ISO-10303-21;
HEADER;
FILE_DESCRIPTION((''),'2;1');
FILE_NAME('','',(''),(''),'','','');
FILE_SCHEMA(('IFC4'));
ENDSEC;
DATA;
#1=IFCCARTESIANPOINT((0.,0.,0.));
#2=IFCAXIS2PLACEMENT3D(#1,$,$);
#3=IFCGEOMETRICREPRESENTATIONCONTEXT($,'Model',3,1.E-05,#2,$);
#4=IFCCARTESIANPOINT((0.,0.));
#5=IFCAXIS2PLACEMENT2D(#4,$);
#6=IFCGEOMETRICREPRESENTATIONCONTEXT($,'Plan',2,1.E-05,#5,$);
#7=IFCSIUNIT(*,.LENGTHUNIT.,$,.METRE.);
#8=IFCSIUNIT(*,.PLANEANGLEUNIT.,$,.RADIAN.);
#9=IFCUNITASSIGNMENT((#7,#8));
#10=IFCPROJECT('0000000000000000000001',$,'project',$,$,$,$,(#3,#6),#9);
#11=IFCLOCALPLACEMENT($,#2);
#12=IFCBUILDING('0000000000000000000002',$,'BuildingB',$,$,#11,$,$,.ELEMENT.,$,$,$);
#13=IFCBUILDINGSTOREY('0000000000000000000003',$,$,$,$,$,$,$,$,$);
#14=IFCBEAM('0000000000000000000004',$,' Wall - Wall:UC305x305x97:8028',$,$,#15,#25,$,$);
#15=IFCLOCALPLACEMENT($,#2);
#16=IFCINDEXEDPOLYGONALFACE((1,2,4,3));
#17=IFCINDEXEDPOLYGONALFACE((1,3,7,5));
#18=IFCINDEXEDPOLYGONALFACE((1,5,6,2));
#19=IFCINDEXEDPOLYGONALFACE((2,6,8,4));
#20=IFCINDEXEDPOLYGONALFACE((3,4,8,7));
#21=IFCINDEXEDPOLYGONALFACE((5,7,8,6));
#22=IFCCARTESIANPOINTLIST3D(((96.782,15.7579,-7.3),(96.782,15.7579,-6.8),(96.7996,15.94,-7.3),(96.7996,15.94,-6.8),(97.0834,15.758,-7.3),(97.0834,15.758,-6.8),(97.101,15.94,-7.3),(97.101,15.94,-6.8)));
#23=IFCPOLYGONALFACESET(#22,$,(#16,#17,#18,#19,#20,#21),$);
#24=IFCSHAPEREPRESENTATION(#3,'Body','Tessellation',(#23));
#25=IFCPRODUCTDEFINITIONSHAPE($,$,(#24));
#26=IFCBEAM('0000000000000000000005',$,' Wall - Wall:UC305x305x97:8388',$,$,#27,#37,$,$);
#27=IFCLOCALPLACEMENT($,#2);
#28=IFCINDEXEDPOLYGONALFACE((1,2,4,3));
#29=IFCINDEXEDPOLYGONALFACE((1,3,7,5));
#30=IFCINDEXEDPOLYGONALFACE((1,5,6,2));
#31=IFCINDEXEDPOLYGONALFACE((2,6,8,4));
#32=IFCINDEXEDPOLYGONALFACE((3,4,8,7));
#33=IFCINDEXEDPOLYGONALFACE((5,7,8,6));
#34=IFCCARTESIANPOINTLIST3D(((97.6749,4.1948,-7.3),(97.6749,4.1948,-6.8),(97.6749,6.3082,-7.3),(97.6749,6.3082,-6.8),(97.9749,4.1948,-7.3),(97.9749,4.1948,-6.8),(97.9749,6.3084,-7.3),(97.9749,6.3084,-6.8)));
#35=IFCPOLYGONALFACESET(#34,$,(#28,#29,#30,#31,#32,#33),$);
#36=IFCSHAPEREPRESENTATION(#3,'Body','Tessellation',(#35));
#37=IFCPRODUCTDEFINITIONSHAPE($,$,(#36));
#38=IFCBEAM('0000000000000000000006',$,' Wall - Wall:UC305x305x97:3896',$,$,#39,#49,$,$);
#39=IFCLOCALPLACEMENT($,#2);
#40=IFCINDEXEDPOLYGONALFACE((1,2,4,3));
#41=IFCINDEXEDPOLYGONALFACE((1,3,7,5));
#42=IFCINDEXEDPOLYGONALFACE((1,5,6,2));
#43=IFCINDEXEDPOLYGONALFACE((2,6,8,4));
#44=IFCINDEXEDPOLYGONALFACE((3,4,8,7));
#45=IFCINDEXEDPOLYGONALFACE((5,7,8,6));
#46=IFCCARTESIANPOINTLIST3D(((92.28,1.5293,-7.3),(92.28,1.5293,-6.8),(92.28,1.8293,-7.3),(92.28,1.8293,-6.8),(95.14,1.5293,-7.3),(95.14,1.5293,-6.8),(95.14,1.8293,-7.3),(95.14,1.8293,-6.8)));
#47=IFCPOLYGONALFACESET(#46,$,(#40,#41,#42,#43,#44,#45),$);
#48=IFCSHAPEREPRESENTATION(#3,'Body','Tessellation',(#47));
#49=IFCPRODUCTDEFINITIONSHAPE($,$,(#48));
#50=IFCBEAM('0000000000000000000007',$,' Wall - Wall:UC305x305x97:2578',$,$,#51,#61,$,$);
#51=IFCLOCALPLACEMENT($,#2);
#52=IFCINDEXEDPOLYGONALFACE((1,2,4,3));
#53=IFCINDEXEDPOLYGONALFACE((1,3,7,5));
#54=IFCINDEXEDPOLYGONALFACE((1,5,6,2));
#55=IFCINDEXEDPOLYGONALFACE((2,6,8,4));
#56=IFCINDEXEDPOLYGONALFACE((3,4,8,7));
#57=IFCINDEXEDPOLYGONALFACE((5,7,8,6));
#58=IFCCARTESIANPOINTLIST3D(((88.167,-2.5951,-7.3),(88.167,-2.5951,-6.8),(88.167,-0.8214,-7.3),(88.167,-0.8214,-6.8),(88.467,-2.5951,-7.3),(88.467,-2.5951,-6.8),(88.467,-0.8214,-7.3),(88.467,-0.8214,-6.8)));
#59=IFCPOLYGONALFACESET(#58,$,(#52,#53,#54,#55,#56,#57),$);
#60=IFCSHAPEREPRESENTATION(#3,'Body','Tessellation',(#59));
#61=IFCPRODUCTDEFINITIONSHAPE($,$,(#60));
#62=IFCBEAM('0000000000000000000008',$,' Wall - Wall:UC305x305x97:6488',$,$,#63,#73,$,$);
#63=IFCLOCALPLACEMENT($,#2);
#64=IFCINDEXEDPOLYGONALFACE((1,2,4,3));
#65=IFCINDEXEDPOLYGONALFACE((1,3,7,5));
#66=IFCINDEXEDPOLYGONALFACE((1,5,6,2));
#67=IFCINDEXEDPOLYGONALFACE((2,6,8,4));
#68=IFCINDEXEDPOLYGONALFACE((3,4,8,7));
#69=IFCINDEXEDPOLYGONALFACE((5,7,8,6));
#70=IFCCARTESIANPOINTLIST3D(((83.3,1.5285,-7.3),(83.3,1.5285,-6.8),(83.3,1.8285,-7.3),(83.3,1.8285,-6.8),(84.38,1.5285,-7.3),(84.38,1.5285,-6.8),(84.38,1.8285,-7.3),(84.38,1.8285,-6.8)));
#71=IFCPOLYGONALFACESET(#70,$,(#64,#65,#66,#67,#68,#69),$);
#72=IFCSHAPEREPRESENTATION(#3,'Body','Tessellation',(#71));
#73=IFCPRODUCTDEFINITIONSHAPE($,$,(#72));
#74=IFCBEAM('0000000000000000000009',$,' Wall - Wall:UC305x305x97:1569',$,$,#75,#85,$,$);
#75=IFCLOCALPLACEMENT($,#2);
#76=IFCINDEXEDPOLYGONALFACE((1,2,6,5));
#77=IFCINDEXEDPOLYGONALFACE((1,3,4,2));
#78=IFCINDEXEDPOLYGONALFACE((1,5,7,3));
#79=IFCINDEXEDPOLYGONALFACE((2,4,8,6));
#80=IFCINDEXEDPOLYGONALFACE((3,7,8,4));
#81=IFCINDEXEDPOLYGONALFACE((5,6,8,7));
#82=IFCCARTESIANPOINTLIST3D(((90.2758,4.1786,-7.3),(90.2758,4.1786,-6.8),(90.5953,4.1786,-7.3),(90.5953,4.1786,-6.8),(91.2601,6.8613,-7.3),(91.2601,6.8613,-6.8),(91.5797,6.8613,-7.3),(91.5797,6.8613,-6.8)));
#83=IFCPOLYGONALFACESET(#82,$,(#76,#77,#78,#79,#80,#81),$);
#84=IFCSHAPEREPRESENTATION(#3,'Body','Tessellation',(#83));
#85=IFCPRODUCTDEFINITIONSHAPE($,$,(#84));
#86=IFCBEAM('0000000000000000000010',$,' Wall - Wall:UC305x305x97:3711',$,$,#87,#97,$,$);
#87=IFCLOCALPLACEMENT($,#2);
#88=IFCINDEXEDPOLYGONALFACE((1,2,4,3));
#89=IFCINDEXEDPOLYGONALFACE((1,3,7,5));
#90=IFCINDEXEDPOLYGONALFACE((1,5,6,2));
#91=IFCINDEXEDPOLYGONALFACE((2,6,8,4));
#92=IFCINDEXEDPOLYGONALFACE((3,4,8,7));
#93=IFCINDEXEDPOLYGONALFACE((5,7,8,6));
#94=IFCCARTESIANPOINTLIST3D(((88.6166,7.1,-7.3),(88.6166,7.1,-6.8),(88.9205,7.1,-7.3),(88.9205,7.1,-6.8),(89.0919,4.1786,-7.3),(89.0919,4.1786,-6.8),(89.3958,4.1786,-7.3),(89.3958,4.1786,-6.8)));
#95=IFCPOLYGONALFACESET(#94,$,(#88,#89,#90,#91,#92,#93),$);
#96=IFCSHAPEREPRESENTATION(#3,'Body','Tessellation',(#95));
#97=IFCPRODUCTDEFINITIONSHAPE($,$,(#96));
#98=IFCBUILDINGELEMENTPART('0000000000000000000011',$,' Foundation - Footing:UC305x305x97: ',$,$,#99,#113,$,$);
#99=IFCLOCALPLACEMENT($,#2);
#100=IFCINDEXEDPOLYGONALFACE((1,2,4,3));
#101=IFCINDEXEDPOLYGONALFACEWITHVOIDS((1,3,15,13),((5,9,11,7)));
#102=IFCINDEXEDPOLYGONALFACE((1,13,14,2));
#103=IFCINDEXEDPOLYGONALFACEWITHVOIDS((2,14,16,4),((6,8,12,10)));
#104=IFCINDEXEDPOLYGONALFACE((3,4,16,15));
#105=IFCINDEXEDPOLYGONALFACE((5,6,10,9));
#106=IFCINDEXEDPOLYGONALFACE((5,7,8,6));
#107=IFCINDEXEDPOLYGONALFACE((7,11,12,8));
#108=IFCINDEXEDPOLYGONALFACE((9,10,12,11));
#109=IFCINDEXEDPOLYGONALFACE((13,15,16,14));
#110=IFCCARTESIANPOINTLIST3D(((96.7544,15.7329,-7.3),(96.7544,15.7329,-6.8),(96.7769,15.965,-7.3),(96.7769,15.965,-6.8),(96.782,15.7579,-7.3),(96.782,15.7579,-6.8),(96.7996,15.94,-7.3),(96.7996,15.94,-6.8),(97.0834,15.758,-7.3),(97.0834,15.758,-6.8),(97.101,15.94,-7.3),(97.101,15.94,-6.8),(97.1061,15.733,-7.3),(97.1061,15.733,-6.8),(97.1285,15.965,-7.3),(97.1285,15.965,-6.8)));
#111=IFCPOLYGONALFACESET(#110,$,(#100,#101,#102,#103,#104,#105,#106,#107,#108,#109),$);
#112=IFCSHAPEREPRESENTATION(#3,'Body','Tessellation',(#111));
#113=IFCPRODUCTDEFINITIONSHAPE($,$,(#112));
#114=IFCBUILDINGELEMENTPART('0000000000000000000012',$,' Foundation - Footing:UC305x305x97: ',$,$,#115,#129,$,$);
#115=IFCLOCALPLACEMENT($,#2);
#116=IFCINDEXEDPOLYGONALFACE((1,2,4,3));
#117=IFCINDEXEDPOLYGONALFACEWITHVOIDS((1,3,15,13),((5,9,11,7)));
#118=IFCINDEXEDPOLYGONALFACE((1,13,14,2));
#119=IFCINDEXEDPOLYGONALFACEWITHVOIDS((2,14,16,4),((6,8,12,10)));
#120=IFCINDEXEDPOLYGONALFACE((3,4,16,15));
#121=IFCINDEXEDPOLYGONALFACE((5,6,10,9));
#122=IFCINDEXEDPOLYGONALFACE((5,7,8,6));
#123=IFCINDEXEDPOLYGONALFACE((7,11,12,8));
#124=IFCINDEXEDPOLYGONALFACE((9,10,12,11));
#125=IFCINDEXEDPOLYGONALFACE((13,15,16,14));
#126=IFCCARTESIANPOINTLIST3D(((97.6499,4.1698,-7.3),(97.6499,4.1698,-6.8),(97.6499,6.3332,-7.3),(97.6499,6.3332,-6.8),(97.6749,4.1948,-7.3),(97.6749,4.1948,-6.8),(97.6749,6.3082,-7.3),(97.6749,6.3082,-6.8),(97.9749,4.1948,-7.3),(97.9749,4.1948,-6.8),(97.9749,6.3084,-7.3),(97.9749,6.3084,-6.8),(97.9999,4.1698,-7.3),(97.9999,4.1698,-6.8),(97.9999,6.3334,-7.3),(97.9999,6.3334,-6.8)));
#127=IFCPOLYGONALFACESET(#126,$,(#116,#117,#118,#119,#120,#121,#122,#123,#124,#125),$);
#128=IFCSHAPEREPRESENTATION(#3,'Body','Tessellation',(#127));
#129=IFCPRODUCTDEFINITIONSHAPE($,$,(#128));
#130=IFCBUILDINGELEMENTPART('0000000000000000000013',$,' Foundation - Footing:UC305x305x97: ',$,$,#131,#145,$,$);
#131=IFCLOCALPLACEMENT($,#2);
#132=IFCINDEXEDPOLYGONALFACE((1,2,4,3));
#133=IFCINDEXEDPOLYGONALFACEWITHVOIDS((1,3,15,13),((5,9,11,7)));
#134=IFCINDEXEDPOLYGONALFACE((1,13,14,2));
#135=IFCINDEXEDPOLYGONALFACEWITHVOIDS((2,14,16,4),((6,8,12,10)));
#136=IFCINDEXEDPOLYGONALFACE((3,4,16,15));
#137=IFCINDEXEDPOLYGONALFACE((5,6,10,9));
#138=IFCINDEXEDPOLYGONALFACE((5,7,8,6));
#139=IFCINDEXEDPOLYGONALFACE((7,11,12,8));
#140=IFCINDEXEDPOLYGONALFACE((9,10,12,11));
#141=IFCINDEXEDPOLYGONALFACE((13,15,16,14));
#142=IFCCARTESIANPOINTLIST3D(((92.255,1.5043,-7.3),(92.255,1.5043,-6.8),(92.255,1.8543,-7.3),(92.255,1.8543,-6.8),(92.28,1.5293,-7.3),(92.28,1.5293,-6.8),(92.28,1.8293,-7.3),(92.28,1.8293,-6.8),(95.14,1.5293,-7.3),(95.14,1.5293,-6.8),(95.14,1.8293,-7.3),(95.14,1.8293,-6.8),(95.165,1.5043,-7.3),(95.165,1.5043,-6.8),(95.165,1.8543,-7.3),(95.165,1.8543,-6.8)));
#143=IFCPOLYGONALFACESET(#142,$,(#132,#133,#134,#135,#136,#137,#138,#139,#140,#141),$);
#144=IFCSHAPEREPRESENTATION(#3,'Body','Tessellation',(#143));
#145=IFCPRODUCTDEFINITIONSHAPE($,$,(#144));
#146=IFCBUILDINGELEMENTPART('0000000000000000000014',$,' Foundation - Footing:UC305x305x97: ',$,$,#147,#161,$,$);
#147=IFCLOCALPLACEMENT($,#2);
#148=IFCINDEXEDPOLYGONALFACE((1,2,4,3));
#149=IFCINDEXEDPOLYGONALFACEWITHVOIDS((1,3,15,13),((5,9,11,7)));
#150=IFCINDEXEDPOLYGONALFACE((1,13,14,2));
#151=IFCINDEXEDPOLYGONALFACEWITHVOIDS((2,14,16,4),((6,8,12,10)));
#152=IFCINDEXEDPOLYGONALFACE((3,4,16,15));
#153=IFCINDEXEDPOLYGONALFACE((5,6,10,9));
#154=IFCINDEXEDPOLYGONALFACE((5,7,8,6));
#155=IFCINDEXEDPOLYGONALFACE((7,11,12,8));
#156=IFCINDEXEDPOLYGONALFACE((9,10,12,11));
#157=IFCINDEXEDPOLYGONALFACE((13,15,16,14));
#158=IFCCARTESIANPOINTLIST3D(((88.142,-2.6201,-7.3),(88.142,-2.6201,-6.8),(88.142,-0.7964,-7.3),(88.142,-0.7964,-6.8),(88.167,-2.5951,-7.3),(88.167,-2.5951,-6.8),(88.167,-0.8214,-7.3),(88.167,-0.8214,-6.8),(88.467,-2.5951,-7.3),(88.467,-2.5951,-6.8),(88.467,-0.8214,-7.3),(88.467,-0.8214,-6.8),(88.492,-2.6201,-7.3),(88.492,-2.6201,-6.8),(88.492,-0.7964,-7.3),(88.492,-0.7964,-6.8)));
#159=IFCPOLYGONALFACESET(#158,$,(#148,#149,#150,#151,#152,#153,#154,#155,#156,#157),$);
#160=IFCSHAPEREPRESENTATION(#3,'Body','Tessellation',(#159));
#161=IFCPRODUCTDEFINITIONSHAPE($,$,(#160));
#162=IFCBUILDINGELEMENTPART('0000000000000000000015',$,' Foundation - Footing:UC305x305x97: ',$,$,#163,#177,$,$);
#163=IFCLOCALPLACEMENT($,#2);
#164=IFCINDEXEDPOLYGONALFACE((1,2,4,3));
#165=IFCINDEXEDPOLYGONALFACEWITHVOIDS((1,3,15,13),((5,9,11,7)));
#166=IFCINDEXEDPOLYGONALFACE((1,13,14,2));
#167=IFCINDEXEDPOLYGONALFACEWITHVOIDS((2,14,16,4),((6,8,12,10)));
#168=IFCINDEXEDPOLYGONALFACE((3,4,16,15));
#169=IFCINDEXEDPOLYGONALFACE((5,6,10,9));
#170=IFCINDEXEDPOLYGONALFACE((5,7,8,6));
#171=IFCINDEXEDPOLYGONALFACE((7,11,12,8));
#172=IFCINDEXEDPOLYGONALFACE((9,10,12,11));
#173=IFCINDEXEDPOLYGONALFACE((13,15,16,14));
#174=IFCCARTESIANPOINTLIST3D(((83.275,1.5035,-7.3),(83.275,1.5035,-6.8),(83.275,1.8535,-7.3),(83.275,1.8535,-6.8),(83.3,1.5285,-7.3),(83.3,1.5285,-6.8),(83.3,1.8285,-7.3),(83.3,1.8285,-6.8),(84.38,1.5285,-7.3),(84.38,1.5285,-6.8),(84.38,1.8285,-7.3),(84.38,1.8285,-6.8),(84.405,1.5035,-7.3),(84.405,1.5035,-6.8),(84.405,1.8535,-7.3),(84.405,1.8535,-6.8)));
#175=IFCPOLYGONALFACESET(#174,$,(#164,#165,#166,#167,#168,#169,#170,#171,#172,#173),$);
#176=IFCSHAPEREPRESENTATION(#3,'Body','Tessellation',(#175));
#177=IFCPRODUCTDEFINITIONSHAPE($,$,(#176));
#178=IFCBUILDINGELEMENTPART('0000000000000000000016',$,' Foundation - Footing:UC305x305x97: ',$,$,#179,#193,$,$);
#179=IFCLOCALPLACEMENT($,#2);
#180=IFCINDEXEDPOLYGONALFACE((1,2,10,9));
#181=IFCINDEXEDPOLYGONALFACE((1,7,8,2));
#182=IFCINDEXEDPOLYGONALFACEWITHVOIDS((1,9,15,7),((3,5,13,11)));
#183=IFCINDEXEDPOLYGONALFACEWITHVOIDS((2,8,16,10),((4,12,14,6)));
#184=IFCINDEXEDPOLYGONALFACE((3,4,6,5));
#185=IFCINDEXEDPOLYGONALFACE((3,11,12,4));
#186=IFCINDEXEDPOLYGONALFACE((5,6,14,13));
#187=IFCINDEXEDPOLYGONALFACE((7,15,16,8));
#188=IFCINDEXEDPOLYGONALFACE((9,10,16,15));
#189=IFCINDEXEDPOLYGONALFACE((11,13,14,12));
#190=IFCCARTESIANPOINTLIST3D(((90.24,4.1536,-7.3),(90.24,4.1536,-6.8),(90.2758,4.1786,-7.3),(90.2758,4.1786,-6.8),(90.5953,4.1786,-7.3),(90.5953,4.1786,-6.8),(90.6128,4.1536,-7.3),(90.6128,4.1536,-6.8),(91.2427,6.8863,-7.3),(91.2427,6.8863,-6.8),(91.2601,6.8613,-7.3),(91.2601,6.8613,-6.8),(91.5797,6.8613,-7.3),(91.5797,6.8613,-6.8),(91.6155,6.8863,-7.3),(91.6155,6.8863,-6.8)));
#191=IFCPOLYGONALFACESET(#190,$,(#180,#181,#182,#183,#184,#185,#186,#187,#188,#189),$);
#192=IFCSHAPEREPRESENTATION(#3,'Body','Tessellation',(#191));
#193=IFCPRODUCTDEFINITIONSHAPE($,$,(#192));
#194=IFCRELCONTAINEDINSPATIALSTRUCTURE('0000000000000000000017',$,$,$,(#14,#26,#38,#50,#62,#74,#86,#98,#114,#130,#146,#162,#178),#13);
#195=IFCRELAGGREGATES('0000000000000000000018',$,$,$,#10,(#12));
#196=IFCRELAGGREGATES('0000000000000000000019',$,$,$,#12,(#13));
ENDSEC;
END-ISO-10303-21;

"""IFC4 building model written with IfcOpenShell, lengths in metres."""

from ifc_helpers import new_model, si_unit, origin, origin_2d, place, context, project, spatial, polyline, outline, extrude, element, save


model = new_model("IFC4")

# Units and contexts
model_context = context("Model", 3, precision=1e-05, world=origin())
plan_context = context("Plan", 2, precision=1e-05, world=origin_2d())
ifc_project = project(units=[si_unit("LENGTHUNIT", "METRE"), si_unit("PLANEANGLEUNIT", "RADIAN")], contexts=[model_context, plan_context])

# Building, storey
building_placement = place(None, origin())
building = spatial("IfcBuilding", under=ifc_project, at=building_placement, Name="BuildingB", CompositionType="ELEMENT")
storey = spatial("IfcBuildingStorey", under=building)

# Beams
element("IfcBeam", 1, inside=storey, Name=" Wall - Wall:UC305x305x97:8028", context=model_context, shape_type="SweptSolid", body=[
    extrude(outline(polyline([(97.0834, 15.758, -7.3), (97.101, 15.94, -7.3), (96.7996, 15.94, -7.3), (96.782, 15.7579, -7.3), (97.0834, 15.758, -7.3)])), None, (0.0, 0.0, 1.0), 0.5),
])
element("IfcBeam", 2, inside=storey, Name=" Wall - Wall:UC305x305x97:8388", context=model_context, shape_type="SweptSolid", body=[
    extrude(outline(polyline([(97.9749, 4.1948, -7.3), (97.9749, 6.3084, -7.3), (97.6749, 6.3082, -7.3), (97.6749, 4.1948, -7.3), (97.9749, 4.1948, -7.3)])), None, (0.0, 0.0, 1.0), 0.5),
])
element("IfcBeam", 3, inside=storey, Name=" Wall - Wall:UC305x305x97:3896", context=model_context, shape_type="SweptSolid", body=[
    extrude(outline(polyline([(95.14, 1.5293, -7.3), (95.14, 1.8293, -7.3), (92.28, 1.8293, -7.3), (92.28, 1.5293, -7.3), (95.14, 1.5293, -7.3)])), None, (0.0, 0.0, 1.0), 0.5),
])
element("IfcBeam", 4, inside=storey, Name=" Wall - Wall:UC305x305x97:2578", context=model_context, shape_type="SweptSolid", body=[
    extrude(outline(polyline([(88.467, -2.5951, -7.3), (88.467, -0.8214, -7.3), (88.167, -0.8214, -7.3), (88.167, -2.5951, -7.3), (88.467, -2.5951, -7.3)])), None, (0.0, 0.0, 1.0), 0.5),
])
element("IfcBeam", 5, inside=storey, Name=" Wall - Wall:UC305x305x97:6488", context=model_context, shape_type="SweptSolid", body=[
    extrude(outline(polyline([(84.38, 1.5285, -7.3), (84.38, 1.8285, -7.3), (83.3, 1.8285, -7.3), (83.3, 1.5285, -7.3), (84.38, 1.5285, -7.3)])), None, (0.0, 0.0, 1.0), 0.5),
])
element("IfcBeam", 6, inside=storey, Name=" Wall - Wall:UC305x305x97:1569", context=model_context, shape_type="SweptSolid", body=[
    extrude(outline(polyline([(90.5953, 4.1786, -7.3), (90.2758, 4.1786, -7.3), (91.2601, 6.8613, -7.3), (91.5797, 6.8613, -7.3), (90.5953, 4.1786, -7.3)])), None, (0.0, 0.0, 1.0), 0.5),
])
element("IfcBeam", 7, inside=storey, Name=" Wall - Wall:UC305x305x97:3711", context=model_context, shape_type="SweptSolid", body=[
    extrude(outline(polyline([(89.3958, 4.1786, -7.3), (89.0919, 4.1786, -7.3), (88.6166, 7.1, -7.3), (88.9205, 7.1, -7.3), (89.3958, 4.1786, -7.3)])), None, (0.0, 0.0, 1.0), 0.5),
])

# Building element parts, openings
building_element_part_1 = element("IfcBuildingElementPart", 8, inside=storey, Name=" Foundation - Footing:UC305x305x97: ", context=model_context, shape_type="SweptSolid", body=[
    extrude(outline(polyline([(97.1061, 15.733, -7.3), (97.1285, 15.965, -7.3), (96.7769, 15.965, -7.3), (96.7544, 15.7329, -7.3), (97.1061, 15.733, -7.3)])), None, (0.0, 0.0, 1.0), 0.5),
])
element("IfcOpeningElement", 9, inside=storey, cuts=building_element_part_1, context=model_context, shape_type="SweptSolid", body=[
    extrude(outline(polyline([(97.0834, 15.758, -7.3), (97.101, 15.94, -7.3), (96.7996, 15.94, -7.3), (96.782, 15.7579, -7.3), (97.0834, 15.758, -7.3)])), None, (0.0, 0.0, 1.0), 0.5),
])
building_element_part_2 = element("IfcBuildingElementPart", 10, inside=storey, Name=" Foundation - Footing:UC305x305x97: ", context=model_context, shape_type="SweptSolid", body=[
    extrude(outline(polyline([(97.9999, 4.1698, -7.3), (97.9999, 6.3334, -7.3), (97.6499, 6.3332, -7.3), (97.6499, 4.1698, -7.3), (97.9999, 4.1698, -7.3)])), None, (0.0, 0.0, 1.0), 0.5),
])
element("IfcOpeningElement", 11, inside=storey, cuts=building_element_part_2, context=model_context, shape_type="SweptSolid", body=[
    extrude(outline(polyline([(97.9749, 4.1948, -7.3), (97.9749, 6.3084, -7.3), (97.6749, 6.3082, -7.3), (97.6749, 4.1948, -7.3), (97.9749, 4.1948, -7.3)])), None, (0.0, 0.0, 1.0), 0.5),
])
building_element_part_3 = element("IfcBuildingElementPart", 12, inside=storey, Name=" Foundation - Footing:UC305x305x97: ", context=model_context, shape_type="SweptSolid", body=[
    extrude(outline(polyline([(95.165, 1.5043, -7.3), (95.165, 1.8543, -7.3), (92.255, 1.8543, -7.3), (92.255, 1.5043, -7.3), (95.165, 1.5043, -7.3)])), None, (0.0, 0.0, 1.0), 0.5),
])
element("IfcOpeningElement", 13, inside=storey, cuts=building_element_part_3, context=model_context, shape_type="SweptSolid", body=[
    extrude(outline(polyline([(95.14, 1.5293, -7.3), (95.14, 1.8293, -7.3), (92.28, 1.8293, -7.3), (92.28, 1.5293, -7.3), (95.14, 1.5293, -7.3)])), None, (0.0, 0.0, 1.0), 0.5),
])
building_element_part_4 = element("IfcBuildingElementPart", 14, inside=storey, Name=" Foundation - Footing:UC305x305x97: ", context=model_context, shape_type="SweptSolid", body=[
    extrude(outline(polyline([(88.492, -2.6201, -7.3), (88.492, -0.7964, -7.3), (88.142, -0.7964, -7.3), (88.142, -2.6201, -7.3), (88.492, -2.6201, -7.3)])), None, (0.0, 0.0, 1.0), 0.5),
])
element("IfcOpeningElement", 15, inside=storey, cuts=building_element_part_4, context=model_context, shape_type="SweptSolid", body=[
    extrude(outline(polyline([(88.467, -2.5951, -7.3), (88.467, -0.8214, -7.3), (88.167, -0.8214, -7.3), (88.167, -2.5951, -7.3), (88.467, -2.5951, -7.3)])), None, (0.0, 0.0, 1.0), 0.5),
])
building_element_part_5 = element("IfcBuildingElementPart", 16, inside=storey, Name=" Foundation - Footing:UC305x305x97: ", context=model_context, shape_type="SweptSolid", body=[
    extrude(outline(polyline([(84.405, 1.5035, -7.3), (84.405, 1.8535, -7.3), (83.275, 1.8535, -7.3), (83.275, 1.5035, -7.3), (84.405, 1.5035, -7.3)])), None, (0.0, 0.0, 1.0), 0.5),
])
element("IfcOpeningElement", 17, inside=storey, cuts=building_element_part_5, context=model_context, shape_type="SweptSolid", body=[
    extrude(outline(polyline([(84.38, 1.5285, -7.3), (84.38, 1.8285, -7.3), (83.3, 1.8285, -7.3), (83.3, 1.5285, -7.3), (84.38, 1.5285, -7.3)])), None, (0.0, 0.0, 1.0), 0.5),
])
building_element_part_6 = element("IfcBuildingElementPart", 18, inside=storey, Name=" Foundation - Footing:UC305x305x97: ", context=model_context, shape_type="SweptSolid", body=[
    extrude(outline(polyline([(90.6128, 4.1536, -7.3), (90.24, 4.1536, -7.3), (91.2427, 6.8863, -7.3), (91.6155, 6.8863, -7.3), (90.6128, 4.1536, -7.3)])), None, (0.0, 0.0, 1.0), 0.5),
])
element("IfcOpeningElement", 19, inside=storey, cuts=building_element_part_6, context=model_context, shape_type="SweptSolid", body=[
    extrude(outline(polyline([(90.5953, 4.1786, -7.3), (90.2758, 4.1786, -7.3), (91.2601, 6.8613, -7.3), (91.5797, 6.8613, -7.3), (90.5953, 4.1786, -7.3)])), None, (0.0, 0.0, 1.0), 0.5),
])

save(model, "model.ifc")
